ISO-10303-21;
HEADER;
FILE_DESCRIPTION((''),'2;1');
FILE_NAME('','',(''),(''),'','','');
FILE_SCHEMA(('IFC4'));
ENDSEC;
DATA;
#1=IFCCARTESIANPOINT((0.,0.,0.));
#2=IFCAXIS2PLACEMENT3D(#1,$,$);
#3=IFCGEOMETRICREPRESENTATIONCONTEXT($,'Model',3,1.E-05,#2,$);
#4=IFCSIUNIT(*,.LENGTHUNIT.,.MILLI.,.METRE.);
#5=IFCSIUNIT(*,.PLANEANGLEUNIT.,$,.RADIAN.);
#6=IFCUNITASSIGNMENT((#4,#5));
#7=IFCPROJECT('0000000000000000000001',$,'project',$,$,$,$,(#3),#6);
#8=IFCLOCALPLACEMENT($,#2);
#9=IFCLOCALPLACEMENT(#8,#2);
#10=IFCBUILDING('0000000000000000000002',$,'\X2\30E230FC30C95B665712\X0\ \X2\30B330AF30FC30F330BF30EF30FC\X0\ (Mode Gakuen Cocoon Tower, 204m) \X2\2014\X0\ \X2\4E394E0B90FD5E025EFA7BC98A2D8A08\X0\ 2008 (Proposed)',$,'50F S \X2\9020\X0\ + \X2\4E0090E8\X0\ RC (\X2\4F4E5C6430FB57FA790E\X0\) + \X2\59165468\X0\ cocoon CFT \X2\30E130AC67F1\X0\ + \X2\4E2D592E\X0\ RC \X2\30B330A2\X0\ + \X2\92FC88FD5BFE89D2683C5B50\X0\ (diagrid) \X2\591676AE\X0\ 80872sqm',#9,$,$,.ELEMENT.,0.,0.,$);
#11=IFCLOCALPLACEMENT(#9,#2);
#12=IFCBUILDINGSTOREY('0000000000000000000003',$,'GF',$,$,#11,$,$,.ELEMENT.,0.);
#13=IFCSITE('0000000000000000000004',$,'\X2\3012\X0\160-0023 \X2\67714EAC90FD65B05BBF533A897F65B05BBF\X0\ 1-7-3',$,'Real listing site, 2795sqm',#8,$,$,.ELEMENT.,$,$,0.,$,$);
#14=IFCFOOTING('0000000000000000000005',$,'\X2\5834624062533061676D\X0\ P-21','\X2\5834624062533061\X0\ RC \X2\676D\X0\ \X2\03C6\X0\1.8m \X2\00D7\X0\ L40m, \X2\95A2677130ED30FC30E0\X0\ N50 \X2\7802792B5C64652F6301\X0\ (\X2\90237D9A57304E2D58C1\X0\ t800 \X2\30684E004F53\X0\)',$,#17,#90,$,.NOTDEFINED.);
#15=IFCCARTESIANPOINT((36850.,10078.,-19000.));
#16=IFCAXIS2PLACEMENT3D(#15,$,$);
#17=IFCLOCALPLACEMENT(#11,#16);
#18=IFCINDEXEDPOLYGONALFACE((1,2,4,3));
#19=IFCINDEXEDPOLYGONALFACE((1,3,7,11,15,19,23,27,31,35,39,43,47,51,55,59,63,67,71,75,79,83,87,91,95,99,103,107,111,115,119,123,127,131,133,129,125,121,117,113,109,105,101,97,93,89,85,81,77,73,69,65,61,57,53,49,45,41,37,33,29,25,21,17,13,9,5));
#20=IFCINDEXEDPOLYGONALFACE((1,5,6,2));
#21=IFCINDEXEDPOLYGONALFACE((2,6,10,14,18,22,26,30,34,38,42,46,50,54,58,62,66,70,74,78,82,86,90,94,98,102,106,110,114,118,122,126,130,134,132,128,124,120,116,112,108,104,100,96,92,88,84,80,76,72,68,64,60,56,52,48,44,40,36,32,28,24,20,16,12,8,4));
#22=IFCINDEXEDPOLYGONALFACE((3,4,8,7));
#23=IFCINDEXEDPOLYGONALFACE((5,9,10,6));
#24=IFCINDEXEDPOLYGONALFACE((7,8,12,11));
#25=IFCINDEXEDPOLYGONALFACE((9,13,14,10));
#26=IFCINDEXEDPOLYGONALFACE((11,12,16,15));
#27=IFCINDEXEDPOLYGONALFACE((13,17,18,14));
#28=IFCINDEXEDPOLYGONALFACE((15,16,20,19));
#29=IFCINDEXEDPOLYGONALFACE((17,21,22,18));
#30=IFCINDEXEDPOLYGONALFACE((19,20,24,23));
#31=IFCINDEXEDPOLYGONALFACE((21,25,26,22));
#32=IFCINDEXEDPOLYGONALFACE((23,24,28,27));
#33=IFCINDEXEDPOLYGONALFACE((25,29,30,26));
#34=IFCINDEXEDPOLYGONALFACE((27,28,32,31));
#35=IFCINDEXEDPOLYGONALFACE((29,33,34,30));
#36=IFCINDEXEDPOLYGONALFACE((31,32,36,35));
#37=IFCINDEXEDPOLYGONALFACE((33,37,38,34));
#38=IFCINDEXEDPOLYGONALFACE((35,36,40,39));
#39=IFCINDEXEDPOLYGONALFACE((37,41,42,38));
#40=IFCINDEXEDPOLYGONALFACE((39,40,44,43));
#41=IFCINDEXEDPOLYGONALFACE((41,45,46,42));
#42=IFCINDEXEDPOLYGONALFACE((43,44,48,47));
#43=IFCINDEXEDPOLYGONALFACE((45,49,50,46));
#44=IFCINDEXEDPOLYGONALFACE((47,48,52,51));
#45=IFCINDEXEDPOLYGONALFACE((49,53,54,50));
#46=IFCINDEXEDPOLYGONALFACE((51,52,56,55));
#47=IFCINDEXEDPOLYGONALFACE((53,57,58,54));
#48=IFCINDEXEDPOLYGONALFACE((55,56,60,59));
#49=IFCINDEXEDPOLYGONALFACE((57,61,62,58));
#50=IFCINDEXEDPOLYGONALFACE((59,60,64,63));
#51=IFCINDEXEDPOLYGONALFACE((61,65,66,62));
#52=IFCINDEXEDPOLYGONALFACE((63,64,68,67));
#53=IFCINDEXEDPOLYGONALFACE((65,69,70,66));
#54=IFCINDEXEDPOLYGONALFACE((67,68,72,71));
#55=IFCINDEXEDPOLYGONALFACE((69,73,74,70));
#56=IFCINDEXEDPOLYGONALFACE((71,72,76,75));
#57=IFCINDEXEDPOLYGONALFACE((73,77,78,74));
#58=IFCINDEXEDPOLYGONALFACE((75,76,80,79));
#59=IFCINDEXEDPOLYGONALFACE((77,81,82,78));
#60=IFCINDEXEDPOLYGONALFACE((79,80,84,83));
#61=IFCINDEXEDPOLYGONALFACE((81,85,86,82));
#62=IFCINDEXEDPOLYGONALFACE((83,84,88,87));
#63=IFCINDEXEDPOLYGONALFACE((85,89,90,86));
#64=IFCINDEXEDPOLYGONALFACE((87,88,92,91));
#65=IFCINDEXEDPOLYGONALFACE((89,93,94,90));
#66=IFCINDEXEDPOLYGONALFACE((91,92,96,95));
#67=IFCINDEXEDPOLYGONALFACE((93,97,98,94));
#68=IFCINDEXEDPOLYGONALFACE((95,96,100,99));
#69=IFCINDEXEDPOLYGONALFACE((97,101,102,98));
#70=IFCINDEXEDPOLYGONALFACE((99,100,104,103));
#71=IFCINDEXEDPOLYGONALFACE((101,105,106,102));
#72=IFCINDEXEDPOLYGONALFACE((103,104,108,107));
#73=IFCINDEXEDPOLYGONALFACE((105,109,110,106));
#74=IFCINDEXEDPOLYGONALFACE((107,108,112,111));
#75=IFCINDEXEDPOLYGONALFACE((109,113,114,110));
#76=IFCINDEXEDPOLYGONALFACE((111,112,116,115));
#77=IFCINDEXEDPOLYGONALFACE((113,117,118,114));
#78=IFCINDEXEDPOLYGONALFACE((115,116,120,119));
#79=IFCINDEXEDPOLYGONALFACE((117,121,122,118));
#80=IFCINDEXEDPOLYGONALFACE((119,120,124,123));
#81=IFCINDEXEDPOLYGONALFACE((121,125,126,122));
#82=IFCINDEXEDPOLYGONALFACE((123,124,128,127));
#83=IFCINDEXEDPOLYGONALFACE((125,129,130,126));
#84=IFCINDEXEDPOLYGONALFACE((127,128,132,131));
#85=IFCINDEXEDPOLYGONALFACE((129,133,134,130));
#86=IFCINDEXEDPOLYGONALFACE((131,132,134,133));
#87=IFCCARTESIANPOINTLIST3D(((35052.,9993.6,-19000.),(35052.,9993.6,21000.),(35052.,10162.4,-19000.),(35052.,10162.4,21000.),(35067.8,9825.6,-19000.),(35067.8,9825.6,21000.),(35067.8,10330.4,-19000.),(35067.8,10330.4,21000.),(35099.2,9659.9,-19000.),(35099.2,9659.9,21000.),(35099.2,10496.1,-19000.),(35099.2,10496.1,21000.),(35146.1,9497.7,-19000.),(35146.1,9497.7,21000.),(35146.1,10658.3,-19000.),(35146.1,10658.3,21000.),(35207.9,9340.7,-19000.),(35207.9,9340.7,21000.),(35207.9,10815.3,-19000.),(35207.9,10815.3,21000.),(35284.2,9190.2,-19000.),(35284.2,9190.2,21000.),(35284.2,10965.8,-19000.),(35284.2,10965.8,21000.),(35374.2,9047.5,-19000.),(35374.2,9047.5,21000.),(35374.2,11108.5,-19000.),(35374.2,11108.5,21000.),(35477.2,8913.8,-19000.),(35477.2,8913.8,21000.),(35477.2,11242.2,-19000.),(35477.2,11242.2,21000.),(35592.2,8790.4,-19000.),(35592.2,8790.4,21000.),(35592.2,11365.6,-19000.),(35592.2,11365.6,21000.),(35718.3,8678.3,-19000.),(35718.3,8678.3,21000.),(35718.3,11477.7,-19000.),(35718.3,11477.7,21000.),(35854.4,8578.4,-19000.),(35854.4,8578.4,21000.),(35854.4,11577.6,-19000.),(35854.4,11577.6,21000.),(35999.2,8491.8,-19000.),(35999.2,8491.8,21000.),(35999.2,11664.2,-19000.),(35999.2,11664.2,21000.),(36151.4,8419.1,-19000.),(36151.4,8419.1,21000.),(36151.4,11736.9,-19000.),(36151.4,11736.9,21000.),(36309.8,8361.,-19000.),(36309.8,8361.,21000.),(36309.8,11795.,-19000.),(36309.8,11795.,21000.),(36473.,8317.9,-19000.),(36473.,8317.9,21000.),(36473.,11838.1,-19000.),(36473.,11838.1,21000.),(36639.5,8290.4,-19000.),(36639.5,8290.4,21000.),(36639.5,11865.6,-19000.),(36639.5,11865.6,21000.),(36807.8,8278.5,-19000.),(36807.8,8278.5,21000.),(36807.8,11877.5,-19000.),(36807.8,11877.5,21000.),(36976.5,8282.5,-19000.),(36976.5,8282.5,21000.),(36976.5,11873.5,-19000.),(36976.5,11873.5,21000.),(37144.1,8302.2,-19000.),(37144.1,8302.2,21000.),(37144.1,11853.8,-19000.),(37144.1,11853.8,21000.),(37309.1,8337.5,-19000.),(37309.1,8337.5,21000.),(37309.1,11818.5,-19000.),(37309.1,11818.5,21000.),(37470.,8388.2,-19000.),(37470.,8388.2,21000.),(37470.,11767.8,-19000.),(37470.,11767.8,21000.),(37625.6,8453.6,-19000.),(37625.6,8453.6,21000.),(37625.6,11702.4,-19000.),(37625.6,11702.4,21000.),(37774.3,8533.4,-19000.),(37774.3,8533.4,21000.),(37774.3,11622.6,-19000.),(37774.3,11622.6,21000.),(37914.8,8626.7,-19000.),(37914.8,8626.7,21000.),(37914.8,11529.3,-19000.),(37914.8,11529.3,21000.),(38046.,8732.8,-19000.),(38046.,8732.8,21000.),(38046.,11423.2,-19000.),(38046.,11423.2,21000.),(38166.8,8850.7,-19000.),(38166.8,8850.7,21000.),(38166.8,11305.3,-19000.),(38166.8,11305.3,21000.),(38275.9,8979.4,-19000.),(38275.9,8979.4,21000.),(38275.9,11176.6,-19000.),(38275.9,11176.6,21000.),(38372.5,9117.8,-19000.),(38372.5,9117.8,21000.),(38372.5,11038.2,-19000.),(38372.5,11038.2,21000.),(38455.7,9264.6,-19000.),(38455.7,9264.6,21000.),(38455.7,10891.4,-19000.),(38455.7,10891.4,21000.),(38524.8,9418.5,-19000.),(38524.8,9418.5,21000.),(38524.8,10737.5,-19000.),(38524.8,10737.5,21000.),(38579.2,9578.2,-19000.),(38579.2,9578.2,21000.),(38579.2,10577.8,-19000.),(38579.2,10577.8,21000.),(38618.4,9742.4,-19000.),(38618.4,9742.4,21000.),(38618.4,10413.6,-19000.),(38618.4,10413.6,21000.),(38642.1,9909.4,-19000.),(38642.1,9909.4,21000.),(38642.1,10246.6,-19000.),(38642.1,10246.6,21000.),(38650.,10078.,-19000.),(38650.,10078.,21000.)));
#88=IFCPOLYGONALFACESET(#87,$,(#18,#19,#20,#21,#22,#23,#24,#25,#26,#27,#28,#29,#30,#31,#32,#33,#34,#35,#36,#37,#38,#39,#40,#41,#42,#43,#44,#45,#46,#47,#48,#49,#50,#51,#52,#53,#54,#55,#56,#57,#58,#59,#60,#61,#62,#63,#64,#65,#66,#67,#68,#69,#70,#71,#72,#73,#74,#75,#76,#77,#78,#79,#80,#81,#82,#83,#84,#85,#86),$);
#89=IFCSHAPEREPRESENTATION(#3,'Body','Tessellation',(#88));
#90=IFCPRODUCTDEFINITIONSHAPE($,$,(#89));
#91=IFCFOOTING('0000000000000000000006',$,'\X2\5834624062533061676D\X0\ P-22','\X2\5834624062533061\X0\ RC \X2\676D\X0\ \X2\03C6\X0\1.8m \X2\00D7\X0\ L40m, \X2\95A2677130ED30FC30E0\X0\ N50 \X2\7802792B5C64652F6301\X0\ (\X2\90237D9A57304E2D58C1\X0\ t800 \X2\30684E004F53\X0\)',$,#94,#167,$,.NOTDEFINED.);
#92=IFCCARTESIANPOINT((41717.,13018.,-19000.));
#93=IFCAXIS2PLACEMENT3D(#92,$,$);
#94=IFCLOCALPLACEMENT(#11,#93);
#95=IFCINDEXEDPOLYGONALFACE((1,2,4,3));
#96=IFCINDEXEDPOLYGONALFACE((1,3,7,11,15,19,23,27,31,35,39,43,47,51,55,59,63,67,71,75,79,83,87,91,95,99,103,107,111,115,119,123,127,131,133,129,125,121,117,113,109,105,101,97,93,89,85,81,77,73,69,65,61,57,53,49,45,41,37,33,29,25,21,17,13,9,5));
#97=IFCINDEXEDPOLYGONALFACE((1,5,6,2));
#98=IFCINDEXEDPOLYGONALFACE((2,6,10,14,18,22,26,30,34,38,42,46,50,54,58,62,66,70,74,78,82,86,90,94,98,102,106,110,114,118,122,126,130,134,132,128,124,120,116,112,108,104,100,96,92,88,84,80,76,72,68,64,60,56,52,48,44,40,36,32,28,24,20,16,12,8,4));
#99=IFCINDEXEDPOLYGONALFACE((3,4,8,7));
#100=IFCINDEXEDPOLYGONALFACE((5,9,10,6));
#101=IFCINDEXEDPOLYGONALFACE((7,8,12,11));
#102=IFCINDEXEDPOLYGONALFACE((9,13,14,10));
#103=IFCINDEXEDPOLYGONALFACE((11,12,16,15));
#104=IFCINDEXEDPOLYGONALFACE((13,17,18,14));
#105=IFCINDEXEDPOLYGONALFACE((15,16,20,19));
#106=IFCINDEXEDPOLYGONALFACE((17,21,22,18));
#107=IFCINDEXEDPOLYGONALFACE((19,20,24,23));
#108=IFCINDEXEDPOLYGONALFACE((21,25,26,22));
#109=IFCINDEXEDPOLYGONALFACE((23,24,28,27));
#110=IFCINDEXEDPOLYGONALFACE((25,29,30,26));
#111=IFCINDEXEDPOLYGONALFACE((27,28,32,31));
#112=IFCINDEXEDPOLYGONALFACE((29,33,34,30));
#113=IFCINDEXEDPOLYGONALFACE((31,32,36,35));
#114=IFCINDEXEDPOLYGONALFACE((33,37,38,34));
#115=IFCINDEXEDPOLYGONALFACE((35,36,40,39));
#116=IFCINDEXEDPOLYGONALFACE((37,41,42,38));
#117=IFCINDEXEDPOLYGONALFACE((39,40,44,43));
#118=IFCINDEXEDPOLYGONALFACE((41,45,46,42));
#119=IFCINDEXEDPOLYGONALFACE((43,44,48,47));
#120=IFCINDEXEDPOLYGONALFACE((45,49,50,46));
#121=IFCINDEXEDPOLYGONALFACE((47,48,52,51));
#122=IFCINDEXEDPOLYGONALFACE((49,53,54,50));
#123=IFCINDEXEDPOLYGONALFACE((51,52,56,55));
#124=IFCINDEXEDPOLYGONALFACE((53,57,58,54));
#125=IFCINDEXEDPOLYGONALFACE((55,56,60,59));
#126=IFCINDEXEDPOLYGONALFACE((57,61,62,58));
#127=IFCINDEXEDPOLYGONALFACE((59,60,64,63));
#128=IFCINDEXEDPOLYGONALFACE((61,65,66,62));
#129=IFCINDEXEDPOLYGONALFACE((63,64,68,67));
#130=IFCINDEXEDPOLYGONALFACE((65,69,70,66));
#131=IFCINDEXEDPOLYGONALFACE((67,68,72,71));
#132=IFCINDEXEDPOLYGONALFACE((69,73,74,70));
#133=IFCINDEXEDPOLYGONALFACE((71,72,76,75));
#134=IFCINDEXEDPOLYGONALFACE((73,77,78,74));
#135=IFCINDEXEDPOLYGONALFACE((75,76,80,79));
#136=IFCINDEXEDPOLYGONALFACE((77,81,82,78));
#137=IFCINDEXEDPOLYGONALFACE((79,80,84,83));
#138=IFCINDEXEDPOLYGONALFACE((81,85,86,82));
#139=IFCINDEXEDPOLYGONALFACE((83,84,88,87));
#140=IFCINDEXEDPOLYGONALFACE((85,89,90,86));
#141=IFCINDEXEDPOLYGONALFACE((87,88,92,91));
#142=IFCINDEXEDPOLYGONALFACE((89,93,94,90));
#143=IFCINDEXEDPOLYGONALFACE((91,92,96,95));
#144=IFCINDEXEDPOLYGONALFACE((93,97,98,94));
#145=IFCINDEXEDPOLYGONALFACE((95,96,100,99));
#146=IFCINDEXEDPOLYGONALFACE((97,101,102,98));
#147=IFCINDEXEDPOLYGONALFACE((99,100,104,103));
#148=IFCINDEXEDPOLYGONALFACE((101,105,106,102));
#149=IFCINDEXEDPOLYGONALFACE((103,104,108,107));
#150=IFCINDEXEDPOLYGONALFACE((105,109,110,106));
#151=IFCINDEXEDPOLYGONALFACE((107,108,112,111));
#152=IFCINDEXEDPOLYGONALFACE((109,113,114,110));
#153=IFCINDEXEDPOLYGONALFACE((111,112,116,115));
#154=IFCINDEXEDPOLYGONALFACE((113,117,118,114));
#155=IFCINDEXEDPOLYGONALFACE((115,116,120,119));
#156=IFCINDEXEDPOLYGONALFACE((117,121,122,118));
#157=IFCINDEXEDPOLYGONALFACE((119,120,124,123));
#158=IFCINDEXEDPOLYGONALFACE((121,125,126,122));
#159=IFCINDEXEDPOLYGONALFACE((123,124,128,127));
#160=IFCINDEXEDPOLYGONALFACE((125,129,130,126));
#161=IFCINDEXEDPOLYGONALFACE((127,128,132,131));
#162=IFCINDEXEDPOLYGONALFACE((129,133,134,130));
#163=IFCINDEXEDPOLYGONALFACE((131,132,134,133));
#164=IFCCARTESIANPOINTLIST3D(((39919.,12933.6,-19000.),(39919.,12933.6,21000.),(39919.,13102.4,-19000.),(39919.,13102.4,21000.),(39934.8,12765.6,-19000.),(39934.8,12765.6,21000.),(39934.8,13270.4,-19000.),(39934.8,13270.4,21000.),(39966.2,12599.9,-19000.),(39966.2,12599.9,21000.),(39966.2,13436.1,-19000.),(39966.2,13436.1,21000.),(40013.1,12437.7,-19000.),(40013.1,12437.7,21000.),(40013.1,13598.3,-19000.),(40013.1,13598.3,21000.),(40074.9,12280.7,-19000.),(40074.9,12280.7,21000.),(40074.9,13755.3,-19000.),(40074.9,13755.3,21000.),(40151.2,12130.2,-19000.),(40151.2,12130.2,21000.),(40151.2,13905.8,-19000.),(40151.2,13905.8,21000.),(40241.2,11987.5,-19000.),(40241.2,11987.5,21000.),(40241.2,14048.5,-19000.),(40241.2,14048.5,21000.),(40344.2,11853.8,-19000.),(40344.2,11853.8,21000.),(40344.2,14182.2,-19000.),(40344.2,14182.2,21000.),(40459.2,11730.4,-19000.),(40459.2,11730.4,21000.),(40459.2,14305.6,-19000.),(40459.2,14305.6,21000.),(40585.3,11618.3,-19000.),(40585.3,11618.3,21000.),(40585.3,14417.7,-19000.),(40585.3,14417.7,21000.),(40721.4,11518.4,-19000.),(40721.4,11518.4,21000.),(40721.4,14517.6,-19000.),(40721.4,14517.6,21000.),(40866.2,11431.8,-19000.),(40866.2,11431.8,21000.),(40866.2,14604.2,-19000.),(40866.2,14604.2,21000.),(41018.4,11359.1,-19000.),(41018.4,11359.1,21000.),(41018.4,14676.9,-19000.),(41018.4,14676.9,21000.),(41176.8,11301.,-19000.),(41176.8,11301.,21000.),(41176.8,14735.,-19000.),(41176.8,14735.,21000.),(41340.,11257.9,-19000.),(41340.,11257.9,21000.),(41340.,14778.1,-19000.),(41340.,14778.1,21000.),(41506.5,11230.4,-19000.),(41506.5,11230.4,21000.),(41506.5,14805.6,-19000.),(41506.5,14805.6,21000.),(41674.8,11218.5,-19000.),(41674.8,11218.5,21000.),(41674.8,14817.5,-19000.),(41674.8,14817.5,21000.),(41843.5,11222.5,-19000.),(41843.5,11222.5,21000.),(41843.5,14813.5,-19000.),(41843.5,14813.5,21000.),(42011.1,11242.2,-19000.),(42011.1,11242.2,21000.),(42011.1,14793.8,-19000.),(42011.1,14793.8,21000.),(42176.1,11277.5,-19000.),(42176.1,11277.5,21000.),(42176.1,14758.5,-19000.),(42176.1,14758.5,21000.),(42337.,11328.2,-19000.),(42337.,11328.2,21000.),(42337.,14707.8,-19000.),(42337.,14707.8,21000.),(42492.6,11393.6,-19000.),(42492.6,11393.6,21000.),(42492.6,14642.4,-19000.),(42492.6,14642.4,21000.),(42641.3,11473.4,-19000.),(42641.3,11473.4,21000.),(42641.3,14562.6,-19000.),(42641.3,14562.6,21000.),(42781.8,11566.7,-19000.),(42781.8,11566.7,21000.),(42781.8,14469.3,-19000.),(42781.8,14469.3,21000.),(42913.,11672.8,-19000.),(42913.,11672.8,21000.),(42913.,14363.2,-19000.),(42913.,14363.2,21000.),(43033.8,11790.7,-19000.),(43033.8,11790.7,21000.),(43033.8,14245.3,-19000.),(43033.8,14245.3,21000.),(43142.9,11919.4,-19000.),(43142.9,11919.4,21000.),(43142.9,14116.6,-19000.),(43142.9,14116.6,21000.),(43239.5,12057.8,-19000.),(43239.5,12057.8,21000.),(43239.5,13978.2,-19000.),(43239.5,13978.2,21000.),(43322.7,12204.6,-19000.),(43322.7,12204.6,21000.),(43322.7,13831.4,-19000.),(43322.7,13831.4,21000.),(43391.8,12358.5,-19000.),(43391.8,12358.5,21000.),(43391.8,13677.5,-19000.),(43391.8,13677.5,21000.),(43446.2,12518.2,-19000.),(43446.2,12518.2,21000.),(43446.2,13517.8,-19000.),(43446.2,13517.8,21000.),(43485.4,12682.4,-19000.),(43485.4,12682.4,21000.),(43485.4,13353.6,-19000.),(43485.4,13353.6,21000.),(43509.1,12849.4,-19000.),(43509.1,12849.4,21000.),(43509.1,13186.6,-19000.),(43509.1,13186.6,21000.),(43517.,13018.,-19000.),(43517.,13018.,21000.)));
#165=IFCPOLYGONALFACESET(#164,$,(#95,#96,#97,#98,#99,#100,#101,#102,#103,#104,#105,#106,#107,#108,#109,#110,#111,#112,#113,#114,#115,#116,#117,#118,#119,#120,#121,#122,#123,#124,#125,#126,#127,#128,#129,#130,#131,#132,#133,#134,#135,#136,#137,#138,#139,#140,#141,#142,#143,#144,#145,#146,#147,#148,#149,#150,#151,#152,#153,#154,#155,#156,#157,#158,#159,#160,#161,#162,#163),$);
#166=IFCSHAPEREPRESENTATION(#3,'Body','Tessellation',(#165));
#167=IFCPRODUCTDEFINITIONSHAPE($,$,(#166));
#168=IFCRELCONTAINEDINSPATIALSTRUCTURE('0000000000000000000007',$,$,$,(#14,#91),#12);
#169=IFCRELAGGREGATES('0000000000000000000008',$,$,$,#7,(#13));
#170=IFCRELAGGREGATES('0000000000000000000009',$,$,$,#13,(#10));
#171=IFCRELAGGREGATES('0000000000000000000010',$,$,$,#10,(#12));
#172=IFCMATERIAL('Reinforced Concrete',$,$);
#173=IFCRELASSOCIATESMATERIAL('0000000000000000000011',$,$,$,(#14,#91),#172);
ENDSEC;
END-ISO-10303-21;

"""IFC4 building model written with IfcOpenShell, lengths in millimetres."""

from ifc_helpers import new_model, si_unit, frame, origin, origin_2d, place, context, project, spatial, circle, extrude, material, element, save


model = new_model("IFC4")

# Units and contexts
model_context = context("Model", 3, precision=1e-05, world=origin())
ifc_project = project(units=[si_unit("LENGTHUNIT", "METRE", prefix="MILLI"), si_unit("PLANEANGLEUNIT", "RADIAN")], contexts=[model_context])

# Site, building, storey
site_placement = place(None, origin())
site = spatial("IfcSite", under=ifc_project, at=site_placement, Name="〒160-0023 東京都新宿区西新宿 1-7-3", ObjectType="Real listing site, 2795sqm", CompositionType="ELEMENT", RefElevation=0.0)
building_placement = place(site_placement, origin())
building = spatial("IfcBuilding", under=site, at=building_placement, Name="モード学園 コクーンタワー (Mode Gakuen Cocoon Tower, 204m) — 丹下都市建築設計 2008 (Proposed)", ObjectType="50F S 造 + 一部 RC (低層・基礎) + 外周 cocoon CFT メガ柱 + 中央 RC コア + 鋼製対角格子 (diagrid) 外皮 80872sqm", CompositionType="ELEMENT", ElevationOfRefHeight=0.0, ElevationOfTerrain=0.0)
storey_placement = place(building_placement, origin())
storey = spatial("IfcBuildingStorey", under=building, at=storey_placement, Name="GF", CompositionType="ELEMENT", Elevation=0.0)

# Footings
ifc_material_1 = material(Name="Reinforced Concrete")
footing_1_placement = place(storey_placement, frame((36850.0, 10078.0, -19000.0)))
element("IfcFooting", 1, at=footing_1_placement, inside=storey, material=ifc_material_1, Name="場所打ち杭 P-21", Description="場所打ち RC 杭 φ1.8m × L40m, 関東ローム N50 砂礫層支持 (連続地中壁 t800 と一体)", PredefinedType="NOTDEFINED", context=model_context, shape_type="SweptSolid", body=[
    extrude(circle(Radius=1800.0, at=origin_2d()), frame((36850.0, 10078.0, -19000.0)), (0.0, 0.0, 1.0), 40000.0),
])
footing_2_placement = place(storey_placement, frame((41717.0, 13018.0, -19000.0)))
element("IfcFooting", 2, at=footing_2_placement, inside=storey, material=ifc_material_1, Name="場所打ち杭 P-22", Description="場所打ち RC 杭 φ1.8m × L40m, 関東ローム N50 砂礫層支持 (連続地中壁 t800 と一体)", PredefinedType="NOTDEFINED", context=model_context, shape_type="SweptSolid", body=[
    extrude(circle(Radius=1800.0, at=origin_2d()), frame((41717.0, 13018.0, -19000.0)), (0.0, 0.0, 1.0), 40000.0),
])

save(model, "model.ifc")
